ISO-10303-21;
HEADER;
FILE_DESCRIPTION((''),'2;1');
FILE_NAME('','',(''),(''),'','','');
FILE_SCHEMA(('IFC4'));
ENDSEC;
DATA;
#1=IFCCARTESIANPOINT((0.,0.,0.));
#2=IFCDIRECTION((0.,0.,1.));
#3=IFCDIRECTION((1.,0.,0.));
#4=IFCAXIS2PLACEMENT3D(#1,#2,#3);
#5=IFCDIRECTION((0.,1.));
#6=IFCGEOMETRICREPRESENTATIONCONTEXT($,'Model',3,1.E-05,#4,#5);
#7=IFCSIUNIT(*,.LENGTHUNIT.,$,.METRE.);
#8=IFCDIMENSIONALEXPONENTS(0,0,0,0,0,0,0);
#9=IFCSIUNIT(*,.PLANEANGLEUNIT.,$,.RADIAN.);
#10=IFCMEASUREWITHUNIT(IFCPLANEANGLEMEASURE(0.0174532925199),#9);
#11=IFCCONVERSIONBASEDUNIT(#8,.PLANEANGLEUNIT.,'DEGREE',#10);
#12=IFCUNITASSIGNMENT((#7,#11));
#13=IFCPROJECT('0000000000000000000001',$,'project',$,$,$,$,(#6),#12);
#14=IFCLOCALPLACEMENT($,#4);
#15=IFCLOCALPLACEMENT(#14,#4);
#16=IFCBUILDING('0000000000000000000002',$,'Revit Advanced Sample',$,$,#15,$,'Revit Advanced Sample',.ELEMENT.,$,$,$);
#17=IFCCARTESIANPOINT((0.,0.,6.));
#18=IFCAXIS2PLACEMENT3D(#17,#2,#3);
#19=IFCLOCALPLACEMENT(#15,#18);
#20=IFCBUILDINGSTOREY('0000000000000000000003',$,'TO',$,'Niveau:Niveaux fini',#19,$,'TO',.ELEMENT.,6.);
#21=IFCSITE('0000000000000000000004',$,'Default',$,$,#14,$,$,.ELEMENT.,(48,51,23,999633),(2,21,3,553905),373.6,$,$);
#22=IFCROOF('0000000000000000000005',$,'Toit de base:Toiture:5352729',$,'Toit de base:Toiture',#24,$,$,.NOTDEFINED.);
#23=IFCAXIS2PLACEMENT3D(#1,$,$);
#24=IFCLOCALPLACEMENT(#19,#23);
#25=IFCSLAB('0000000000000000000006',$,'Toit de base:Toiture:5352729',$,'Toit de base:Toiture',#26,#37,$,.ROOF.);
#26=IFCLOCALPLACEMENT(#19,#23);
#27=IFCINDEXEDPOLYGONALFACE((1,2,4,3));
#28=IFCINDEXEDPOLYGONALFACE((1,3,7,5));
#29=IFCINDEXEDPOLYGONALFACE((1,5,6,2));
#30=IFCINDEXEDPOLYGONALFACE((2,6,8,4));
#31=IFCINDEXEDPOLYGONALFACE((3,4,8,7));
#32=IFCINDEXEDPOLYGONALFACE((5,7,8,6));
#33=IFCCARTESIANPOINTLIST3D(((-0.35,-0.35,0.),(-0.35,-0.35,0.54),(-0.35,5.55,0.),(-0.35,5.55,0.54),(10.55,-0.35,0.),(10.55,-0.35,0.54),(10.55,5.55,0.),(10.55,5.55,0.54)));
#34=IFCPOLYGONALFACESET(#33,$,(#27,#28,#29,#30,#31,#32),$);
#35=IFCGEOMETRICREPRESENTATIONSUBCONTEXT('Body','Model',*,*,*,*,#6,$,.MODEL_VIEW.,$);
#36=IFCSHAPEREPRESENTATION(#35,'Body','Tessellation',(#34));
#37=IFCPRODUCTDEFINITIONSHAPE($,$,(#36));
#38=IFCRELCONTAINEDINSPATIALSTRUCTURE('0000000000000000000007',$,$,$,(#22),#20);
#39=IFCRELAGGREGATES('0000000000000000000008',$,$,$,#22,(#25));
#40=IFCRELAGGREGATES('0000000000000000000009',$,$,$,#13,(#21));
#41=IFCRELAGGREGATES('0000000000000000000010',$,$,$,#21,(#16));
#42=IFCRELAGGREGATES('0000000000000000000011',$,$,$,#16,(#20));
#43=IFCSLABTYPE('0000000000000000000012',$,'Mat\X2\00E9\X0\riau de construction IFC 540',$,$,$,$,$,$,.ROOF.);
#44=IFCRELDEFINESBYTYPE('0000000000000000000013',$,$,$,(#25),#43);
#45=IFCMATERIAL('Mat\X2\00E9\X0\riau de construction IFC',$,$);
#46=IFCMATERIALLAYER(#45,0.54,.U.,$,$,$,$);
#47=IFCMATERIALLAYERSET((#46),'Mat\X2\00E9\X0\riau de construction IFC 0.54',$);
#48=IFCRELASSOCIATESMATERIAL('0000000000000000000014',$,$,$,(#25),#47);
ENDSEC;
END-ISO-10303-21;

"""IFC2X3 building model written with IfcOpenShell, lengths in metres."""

from ifc_helpers import new_model, entity, si_unit, converted_unit, direction, frame, origin_with_axes, place, context, subcontext, project, spatial, polyline, outline, extrude, material, layer, layer_set, layer_usage, type_object, element, aggregate, save


model = new_model("IFC2X3")

# Units and contexts
model_context = context("Model", 3, precision=1e-05, world=origin_with_axes(), true_north=direction((0.0, 1.0)))
body_context = subcontext(model_context, "Body", "Model", "MODEL_VIEW")
ifc_project = project(units=[si_unit("LENGTHUNIT", "METRE"), converted_unit("PLANEANGLEUNIT", "DEGREE", entity("IfcPlaneAngleMeasure", 0.0174532925199), si_unit("PLANEANGLEUNIT", "RADIAN"), dimensions=[0, 0, 0, 0, 0, 0, 0])], contexts=[model_context])

# Site, building, storey
site_placement = place(None, origin_with_axes())
site = spatial("IfcSite", under=ifc_project, at=site_placement, Name="Default", CompositionType="ELEMENT", RefLatitude=(48, 51, 23, 999633), RefLongitude=(2, 21, 3, 553905), RefElevation=373.6)
building_placement = place(site_placement, origin_with_axes())
building = spatial("IfcBuilding", under=site, at=building_placement, Name="Revit Advanced Sample", LongName="Revit Advanced Sample", CompositionType="ELEMENT")
storey_placement = place(building_placement, frame((0.0, 0.0, 6.0), z_axis=(0.0, 0.0, 1.0), x_axis=(1.0, 0.0, 0.0)))
storey = spatial("IfcBuildingStorey", under=building, at=storey_placement, Name="TO", ObjectType="Niveau:Niveaux fini", LongName="TO", CompositionType="ELEMENT", Elevation=6.0)

# Roof, slab
roof_placement = place(storey_placement, frame((0.0, 0.0, -6.0), z_axis=(0.0, 0.0, 1.0), x_axis=(1.0, 0.0, 0.0)))
roof = element("IfcRoof", 1, at=roof_placement, inside=storey, Name="Toit de base:Toiture:5352729", ObjectType="Toit de base:Toiture", ShapeType="NOTDEFINED")
ifc_material = material(Name="Matériau de construction IFC")
ifc_layer = layer(ifc_material, 0.54, ventilated="UNKNOWN")
ifc_layer_set = layer_set([ifc_layer], Name="Matériau de construction IFC 0.54")
ifc_layer_usage = layer_usage(ifc_layer_set, "AXIS3", "NEGATIVE", 0.54)
slab_type = type_object("IfcSlabType", Name="Matériau de construction IFC 540", PredefinedType="ROOF")
slab_placement = place(roof_placement, frame((5.1, -0.35, 6.0), z_axis=(0.0, 0.0, 1.0), x_axis=(0.0, 1.0, 0.0)))
slab = element("IfcSlab", 2, at=slab_placement, type_object=slab_type, material=ifc_layer_usage, Name="Toit de base:Toiture:5352729", ObjectType="Toit de base:Toiture", PredefinedType="ROOF", context=body_context, shape_type="SweptSolid", body=[
    extrude(outline(polyline([(0.0, -5.45), (5.9, -5.45), (5.9, 5.45), (0.0, 5.45), (0.0, -5.45)])), origin_with_axes(), (0.0, 0.0, 1.0), 0.54),
])
aggregate(roof, [slab])

save(model, "model.ifc")
